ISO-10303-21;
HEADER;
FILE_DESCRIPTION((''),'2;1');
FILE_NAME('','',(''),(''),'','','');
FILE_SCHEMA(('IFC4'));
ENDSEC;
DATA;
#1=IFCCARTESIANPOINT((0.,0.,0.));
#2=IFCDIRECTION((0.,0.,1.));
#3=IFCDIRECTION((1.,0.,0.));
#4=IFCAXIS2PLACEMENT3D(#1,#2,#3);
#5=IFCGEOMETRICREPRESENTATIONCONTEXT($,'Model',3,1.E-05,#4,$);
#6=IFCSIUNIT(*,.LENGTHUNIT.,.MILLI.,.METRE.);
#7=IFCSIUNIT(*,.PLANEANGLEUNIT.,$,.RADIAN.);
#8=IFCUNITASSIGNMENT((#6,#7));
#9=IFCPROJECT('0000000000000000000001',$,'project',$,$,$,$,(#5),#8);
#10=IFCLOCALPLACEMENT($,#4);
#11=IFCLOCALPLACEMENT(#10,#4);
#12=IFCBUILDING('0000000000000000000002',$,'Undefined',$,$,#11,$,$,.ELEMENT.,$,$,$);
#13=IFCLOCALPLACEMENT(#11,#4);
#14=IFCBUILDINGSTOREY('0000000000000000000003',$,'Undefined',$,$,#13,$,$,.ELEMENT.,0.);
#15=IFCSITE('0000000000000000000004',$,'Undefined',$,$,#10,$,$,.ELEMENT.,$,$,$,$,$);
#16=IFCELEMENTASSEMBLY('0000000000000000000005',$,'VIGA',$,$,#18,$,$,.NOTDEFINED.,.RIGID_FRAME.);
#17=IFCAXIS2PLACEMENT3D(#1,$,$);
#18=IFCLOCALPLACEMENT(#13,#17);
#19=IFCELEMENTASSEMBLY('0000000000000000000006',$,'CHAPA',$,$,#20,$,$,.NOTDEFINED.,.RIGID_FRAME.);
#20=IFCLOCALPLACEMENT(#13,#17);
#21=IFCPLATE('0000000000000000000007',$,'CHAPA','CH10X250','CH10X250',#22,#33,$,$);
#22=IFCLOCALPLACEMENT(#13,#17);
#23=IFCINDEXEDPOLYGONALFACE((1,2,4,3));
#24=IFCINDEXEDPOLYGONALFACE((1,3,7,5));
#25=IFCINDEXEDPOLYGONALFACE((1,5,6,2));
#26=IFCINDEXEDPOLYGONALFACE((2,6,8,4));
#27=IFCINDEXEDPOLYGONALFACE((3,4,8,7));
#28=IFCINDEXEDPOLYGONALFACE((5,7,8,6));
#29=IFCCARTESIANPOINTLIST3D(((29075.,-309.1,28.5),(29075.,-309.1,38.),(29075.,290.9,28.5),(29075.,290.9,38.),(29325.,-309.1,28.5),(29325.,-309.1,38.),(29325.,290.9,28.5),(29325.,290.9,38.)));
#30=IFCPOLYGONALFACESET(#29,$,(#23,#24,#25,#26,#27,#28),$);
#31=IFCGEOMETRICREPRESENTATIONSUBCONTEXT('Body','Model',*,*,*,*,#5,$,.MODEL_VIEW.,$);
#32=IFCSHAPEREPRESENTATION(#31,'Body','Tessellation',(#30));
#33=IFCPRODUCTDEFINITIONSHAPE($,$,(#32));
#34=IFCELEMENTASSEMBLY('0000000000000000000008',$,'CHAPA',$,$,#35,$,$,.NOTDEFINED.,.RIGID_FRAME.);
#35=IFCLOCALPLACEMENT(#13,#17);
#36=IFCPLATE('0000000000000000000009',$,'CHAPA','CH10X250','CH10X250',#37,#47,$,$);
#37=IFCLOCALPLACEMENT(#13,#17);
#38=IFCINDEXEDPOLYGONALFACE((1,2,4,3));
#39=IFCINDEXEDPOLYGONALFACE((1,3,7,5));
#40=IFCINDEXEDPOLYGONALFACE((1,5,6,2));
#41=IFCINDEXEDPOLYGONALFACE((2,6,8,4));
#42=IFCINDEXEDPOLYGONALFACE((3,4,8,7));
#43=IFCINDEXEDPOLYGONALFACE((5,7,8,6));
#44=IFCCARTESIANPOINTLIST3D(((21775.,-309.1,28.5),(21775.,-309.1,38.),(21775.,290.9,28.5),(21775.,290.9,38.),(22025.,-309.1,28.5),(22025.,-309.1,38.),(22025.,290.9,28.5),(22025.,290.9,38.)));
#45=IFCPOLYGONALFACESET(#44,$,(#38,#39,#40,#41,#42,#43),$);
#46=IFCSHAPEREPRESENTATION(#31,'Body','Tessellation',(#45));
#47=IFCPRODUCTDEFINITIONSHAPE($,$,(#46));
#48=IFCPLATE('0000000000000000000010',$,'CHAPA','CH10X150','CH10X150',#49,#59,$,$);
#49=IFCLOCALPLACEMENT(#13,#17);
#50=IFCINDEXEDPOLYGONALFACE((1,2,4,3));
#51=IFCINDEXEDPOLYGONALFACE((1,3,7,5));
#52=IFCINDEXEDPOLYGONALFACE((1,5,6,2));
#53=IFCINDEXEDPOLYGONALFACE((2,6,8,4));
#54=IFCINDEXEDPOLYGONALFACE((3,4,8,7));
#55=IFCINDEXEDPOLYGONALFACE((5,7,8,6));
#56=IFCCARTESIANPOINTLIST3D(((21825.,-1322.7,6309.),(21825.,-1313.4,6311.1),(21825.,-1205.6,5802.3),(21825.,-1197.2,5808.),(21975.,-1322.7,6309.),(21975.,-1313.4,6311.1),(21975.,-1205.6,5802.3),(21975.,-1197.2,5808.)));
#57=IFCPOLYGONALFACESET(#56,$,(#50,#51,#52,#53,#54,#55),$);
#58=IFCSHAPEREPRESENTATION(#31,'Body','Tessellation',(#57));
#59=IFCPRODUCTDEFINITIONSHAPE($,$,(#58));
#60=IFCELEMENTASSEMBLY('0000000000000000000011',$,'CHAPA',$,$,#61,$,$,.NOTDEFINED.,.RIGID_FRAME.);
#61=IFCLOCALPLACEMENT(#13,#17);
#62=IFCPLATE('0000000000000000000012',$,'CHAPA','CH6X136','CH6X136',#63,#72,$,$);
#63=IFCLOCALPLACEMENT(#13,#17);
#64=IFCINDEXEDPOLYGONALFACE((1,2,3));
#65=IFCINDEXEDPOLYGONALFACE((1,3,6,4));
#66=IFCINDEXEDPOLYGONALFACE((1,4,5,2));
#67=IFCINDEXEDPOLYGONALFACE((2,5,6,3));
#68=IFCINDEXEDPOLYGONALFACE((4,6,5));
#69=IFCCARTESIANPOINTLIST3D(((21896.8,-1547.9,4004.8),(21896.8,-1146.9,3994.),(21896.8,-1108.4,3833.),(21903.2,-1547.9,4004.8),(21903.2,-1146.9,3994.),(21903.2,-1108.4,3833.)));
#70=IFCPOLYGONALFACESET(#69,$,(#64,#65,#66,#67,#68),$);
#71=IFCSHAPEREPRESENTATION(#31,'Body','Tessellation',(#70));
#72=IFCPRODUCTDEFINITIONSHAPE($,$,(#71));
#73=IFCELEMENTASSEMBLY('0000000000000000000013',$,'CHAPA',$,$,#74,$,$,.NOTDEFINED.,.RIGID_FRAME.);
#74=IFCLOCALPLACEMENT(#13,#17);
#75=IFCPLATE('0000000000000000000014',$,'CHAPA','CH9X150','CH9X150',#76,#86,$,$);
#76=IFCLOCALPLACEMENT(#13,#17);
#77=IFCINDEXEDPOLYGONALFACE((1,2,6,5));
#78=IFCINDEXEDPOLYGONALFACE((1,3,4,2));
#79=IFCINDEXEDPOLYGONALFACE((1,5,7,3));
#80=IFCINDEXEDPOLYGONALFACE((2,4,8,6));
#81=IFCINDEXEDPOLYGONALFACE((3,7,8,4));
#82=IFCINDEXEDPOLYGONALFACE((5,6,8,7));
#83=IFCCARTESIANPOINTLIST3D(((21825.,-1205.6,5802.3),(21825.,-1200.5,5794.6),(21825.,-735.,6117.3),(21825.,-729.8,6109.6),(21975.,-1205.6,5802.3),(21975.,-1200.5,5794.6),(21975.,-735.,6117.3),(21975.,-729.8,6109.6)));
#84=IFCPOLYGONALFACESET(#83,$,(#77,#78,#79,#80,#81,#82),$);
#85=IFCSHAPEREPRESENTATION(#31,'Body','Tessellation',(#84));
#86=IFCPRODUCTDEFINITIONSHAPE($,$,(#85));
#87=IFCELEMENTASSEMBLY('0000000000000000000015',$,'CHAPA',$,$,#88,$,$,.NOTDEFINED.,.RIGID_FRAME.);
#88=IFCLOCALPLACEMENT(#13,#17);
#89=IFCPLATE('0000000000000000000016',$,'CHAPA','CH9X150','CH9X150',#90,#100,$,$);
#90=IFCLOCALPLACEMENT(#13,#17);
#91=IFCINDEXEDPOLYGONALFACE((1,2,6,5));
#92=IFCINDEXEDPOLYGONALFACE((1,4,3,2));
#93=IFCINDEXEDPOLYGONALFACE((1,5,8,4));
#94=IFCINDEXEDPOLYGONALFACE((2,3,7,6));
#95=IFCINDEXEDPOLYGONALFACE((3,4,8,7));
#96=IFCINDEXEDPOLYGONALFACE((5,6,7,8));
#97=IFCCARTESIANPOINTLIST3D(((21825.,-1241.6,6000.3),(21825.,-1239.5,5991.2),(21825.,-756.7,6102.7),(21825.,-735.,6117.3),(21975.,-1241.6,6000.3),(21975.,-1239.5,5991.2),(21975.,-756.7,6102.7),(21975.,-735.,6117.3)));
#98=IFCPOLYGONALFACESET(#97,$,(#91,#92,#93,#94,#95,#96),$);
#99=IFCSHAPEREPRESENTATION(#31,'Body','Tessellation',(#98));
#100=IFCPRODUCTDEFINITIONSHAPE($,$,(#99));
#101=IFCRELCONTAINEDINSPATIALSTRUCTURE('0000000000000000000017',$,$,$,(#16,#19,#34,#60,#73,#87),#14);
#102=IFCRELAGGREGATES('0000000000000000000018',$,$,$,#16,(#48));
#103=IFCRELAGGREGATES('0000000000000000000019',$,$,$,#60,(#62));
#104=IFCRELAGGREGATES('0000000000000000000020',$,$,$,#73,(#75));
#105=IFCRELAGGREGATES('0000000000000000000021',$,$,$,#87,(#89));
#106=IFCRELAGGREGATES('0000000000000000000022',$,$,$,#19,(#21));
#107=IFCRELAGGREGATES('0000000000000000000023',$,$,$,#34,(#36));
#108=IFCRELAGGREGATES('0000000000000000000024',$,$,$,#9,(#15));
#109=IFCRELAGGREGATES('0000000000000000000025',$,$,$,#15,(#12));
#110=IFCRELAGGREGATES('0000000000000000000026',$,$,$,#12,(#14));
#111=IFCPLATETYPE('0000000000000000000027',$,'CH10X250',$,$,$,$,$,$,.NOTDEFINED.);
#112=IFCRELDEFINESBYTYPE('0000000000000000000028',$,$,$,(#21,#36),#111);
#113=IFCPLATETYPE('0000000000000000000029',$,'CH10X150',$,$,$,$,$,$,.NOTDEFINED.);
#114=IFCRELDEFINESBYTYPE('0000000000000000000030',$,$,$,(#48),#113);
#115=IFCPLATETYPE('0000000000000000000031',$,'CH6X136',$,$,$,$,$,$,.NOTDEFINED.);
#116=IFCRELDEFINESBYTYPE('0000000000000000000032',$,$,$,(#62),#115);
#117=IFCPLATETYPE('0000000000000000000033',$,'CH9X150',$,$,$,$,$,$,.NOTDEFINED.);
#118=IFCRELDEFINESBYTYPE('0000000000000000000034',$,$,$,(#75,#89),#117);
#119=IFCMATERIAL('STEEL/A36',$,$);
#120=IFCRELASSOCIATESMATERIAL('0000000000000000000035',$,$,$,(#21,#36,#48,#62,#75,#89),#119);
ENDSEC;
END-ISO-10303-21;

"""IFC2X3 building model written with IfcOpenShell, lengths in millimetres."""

from ifc_helpers import new_model, si_unit, frame, origin_with_axes, place, context, subcontext, project, spatial, polyline, outline, extrude, clip, halfspace, material, type_object, element, aggregate, save


model = new_model("IFC2X3")

# Units and contexts
model_context = context("Model", 3, precision=1e-05, world=origin_with_axes())
body_context = subcontext(model_context, "Body", "Model", "MODEL_VIEW")
ifc_project = project(units=[si_unit("LENGTHUNIT", "METRE", prefix="MILLI"), si_unit("PLANEANGLEUNIT", "RADIAN")], contexts=[model_context])

# Site, building, storey
site_placement = place(None, origin_with_axes())
site = spatial("IfcSite", under=ifc_project, at=site_placement, Name="Undefined", CompositionType="ELEMENT")
building_placement = place(site_placement, origin_with_axes())
building = spatial("IfcBuilding", under=site, at=building_placement, Name="Undefined", CompositionType="ELEMENT")
storey_placement = place(building_placement, origin_with_axes())
storey = spatial("IfcBuildingStorey", under=building, at=storey_placement, Name="Undefined", CompositionType="ELEMENT", Elevation=0.0)

# Element assembly
assembly_1_placement = place(storey_placement, origin_with_axes())
assembly_1 = element("IfcElementAssembly", 1, at=assembly_1_placement, inside=storey, Name="VIGA", AssemblyPlace="NOTDEFINED", PredefinedType="RIGID_FRAME")

# Element assemblies, plates
assembly_2_placement = place(storey_placement, origin_with_axes())
assembly_2 = element("IfcElementAssembly", 2, at=assembly_2_placement, inside=storey, Name="CHAPA", AssemblyPlace="NOTDEFINED", PredefinedType="RIGID_FRAME")
ifc_material_1 = material(Name="STEEL/A36")
plate_type_1 = type_object("IfcPlateType", Name="CH10X250", PredefinedType="NOTDEFINED")
plate_1_placement = place(assembly_2_placement, frame((29075.0, -309.1, 33.2), z_axis=(0.0, 0.0, 1.0), x_axis=(1.0, 0.0, 0.0)))
plate_1 = element("IfcPlate", 3, at=plate_1_placement, type_object=plate_type_1, material=ifc_material_1, Name="CHAPA", Description="CH10X250", ObjectType="CH10X250", context=body_context, shape_type="SweptSolid", body=[
    extrude(outline(polyline([(0.0, 0.0), (250.0, 0.0), (250.0, 600.0), (0.0, 600.0), (0.0, 0.0)])), frame((0.0, 0.0, -4.8), z_axis=(0.0, 0.0, 1.0), x_axis=(1.0, 0.0, 0.0)), (0.0, 0.0, 1.0), 9.5),
])
assembly_3_placement = place(storey_placement, origin_with_axes())
assembly_3 = element("IfcElementAssembly", 4, at=assembly_3_placement, inside=storey, Name="CHAPA", AssemblyPlace="NOTDEFINED", PredefinedType="RIGID_FRAME")
plate_2_placement = place(assembly_3_placement, frame((21775.0, -309.1, 33.2), z_axis=(0.0, 0.0, 1.0), x_axis=(1.0, 0.0, 0.0)))
plate_2 = element("IfcPlate", 5, at=plate_2_placement, type_object=plate_type_1, material=ifc_material_1, Name="CHAPA", Description="CH10X250", ObjectType="CH10X250", context=body_context, shape_type="SweptSolid", body=[
    extrude(outline(polyline([(0.0, 0.0), (250.0, 0.0), (250.0, 600.0), (0.0, 600.0), (0.0, 0.0)])), frame((0.0, 0.0, -4.8), z_axis=(0.0, 0.0, 1.0), x_axis=(1.0, 0.0, 0.0)), (0.0, 0.0, 1.0), 9.5),
])

# Plate
plate_type_2 = type_object("IfcPlateType", Name="CH10X150", PredefinedType="NOTDEFINED")
plate_3_placement = place(assembly_1_placement, frame((21975.0, -1318.1, 6310.1), z_axis=(0.0, 0.97433, 0.225124), x_axis=(0.0, 0.225124, -0.97433)))
plate_3 = element("IfcPlate", 6, at=plate_3_placement, type_object=plate_type_2, material=ifc_material_1, Name="CHAPA", Description="CH10X150", ObjectType="CH10X150", context=body_context, shape_type="Clipping", body=[
    clip(extrude(outline(polyline([(0.0, 0.0), (520.0, 0.0), (520.0, 150.0), (0.0, 150.0), (0.0, 0.0)])), frame((0.0, 0.0, -4.8), z_axis=(0.0, 0.0, 1.0), x_axis=(1.0, 0.0, 0.0)), (0.0, 0.0, 1.0), 9.5), halfspace(frame((516.4, -500.0, 4.8), z_axis=(0.934951, 0.0, 0.354778), x_axis=(0.0, 1.0, 0.0)), False)),
])
aggregate(assembly_1, [plate_3])

# Element assemblies, plates
assembly_4_placement = place(storey_placement, origin_with_axes())
assembly_4 = element("IfcElementAssembly", 7, at=assembly_4_placement, inside=storey, Name="CHAPA", AssemblyPlace="NOTDEFINED", PredefinedType="RIGID_FRAME")
plate_type_3 = type_object("IfcPlateType", Name="CH6X136", PredefinedType="NOTDEFINED")
plate_4_placement = place(assembly_4_placement, frame((21900.0, -1146.9, 3994.0), z_axis=(1.0, 0.0, 0.0), x_axis=(0.0, -0.999636, 0.026972)))
plate_4 = element("IfcPlate", 8, at=plate_4_placement, type_object=plate_type_3, material=ifc_material_1, Name="CHAPA", Description="CH6X136", ObjectType="CH6X136", context=body_context, shape_type="SweptSolid", body=[
    extrude(outline(polyline([(0.0, 0.0), (401.1, 0.0), (-42.8, 159.9), (0.0, 0.0)])), frame((0.0, 0.0, -3.1), z_axis=(0.0, 0.0, 1.0), x_axis=(1.0, 0.0, 0.0)), (0.0, 0.0, 1.0), 6.3),
])
aggregate(assembly_4, [plate_4])
assembly_5_placement = place(storey_placement, origin_with_axes())
assembly_5 = element("IfcElementAssembly", 9, at=assembly_5_placement, inside=storey, Name="CHAPA", AssemblyPlace="NOTDEFINED", PredefinedType="RIGID_FRAME")
plate_type_4 = type_object("IfcPlateType", Name="CH9X150", PredefinedType="NOTDEFINED")
plate_5_placement = place(assembly_5_placement, frame((21975.0, -732.4, 6113.5), z_axis=(0.0, -0.55615, 0.831082), x_axis=(-1.0, 0.0, 0.0)))
plate_5 = element("IfcPlate", 10, at=plate_5_placement, type_object=plate_type_4, material=ifc_material_1, Name="CHAPA", Description="CH9X150", ObjectType="CH9X150", context=body_context, shape_type="SweptSolid", body=[
    extrude(outline(polyline([(0.0, 0.0), (150.0, 0.0), (150.0, 566.3), (0.0, 566.3), (0.0, 0.0)])), frame((0.0, 0.0, -4.7), z_axis=(0.0, 0.0, 1.0), x_axis=(1.0, 0.0, 0.0)), (0.0, 0.0, 1.0), 9.3),
])
aggregate(assembly_5, [plate_5])
assembly_6_placement = place(storey_placement, origin_with_axes())
assembly_6 = element("IfcElementAssembly", 11, at=assembly_6_placement, inside=storey, Name="CHAPA", AssemblyPlace="NOTDEFINED", PredefinedType="RIGID_FRAME")
plate_6_placement = place(assembly_6_placement, frame((21975.0, -1240.6, 5995.7), z_axis=(0.0, -0.225124, 0.97433), x_axis=(0.0, 0.97433, 0.225124)))
plate_6 = element("IfcPlate", 12, at=plate_6_placement, type_object=plate_type_4, material=ifc_material_1, Name="CHAPA", Description="CH9X150", ObjectType="CH9X150", context=body_context, shape_type="Clipping", body=[
    clip(extrude(outline(polyline([(0.0, 0.0), (520.0, 0.0), (520.0, 150.0), (0.0, 150.0), (0.0, 0.0)])), frame((0.0, 0.0, -4.7), z_axis=(0.0, 0.0, 1.0), x_axis=(1.0, 0.0, 0.0)), (0.0, 0.0, 1.0), 9.3), halfspace(frame((520.0, -500.0, 4.7), z_axis=(0.354778, 0.0, -0.934951), x_axis=(0.0, 1.0, 0.0)), False)),
])
aggregate(assembly_6, [plate_6])

aggregate(assembly_2, [plate_1])
aggregate(assembly_3, [plate_2])

save(model, "model.ifc")
